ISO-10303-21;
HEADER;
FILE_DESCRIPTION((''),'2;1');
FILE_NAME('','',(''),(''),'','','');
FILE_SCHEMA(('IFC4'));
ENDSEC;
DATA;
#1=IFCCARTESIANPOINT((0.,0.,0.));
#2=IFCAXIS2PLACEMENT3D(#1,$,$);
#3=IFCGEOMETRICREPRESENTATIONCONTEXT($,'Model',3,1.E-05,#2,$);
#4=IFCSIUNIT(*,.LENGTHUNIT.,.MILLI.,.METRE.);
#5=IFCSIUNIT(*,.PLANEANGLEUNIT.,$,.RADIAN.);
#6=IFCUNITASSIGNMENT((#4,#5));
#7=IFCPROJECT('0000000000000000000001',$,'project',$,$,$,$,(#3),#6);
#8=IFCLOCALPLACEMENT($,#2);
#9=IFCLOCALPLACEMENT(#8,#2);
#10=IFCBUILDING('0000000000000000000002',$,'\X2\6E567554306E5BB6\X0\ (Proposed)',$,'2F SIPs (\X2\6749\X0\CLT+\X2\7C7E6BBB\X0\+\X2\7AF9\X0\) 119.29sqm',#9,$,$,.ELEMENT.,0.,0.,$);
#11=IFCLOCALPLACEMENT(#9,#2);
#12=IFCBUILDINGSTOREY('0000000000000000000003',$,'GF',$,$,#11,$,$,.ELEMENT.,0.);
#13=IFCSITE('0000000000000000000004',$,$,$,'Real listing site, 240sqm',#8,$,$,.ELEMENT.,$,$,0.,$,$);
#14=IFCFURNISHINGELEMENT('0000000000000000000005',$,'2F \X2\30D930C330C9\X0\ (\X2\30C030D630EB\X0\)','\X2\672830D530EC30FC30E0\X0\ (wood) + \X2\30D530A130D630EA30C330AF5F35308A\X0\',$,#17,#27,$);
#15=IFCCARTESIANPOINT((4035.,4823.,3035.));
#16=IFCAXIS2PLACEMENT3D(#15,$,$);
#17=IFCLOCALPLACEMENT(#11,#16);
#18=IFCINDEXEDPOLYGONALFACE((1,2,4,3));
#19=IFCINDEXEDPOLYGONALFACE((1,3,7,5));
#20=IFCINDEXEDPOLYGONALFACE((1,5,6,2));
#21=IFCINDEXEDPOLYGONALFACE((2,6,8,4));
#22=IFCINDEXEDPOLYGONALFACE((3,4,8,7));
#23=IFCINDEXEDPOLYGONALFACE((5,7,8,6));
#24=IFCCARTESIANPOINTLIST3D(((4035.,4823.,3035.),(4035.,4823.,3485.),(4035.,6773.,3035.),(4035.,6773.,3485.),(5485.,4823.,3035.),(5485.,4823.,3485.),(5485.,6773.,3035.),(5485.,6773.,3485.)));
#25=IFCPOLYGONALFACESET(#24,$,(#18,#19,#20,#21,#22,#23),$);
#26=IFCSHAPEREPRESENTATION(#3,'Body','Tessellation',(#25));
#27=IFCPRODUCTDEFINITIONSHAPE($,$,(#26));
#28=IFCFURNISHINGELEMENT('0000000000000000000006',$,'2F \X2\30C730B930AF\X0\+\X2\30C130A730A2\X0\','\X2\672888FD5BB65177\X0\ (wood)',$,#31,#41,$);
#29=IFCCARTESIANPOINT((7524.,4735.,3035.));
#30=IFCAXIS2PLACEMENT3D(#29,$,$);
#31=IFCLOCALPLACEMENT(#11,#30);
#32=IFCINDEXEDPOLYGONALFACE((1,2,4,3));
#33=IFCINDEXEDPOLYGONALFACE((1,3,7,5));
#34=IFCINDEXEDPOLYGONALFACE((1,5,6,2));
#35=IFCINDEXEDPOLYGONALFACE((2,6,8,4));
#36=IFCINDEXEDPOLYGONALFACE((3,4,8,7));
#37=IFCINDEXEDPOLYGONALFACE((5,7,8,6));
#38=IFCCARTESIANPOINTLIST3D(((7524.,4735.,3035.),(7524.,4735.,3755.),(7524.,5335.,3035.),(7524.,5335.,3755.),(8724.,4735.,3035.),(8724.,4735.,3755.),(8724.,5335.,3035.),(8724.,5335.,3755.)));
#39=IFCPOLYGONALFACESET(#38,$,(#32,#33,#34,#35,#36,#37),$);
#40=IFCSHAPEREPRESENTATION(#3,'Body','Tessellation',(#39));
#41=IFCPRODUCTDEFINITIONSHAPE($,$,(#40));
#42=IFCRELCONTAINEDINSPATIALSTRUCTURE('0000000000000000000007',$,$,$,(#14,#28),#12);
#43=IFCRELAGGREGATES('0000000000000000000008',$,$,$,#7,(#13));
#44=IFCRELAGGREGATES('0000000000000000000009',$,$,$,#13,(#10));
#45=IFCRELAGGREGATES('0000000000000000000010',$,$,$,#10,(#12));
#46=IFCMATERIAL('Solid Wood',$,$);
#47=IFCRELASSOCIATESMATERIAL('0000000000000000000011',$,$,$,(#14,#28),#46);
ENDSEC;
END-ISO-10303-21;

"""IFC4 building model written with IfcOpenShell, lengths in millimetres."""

from ifc_helpers import new_model, si_unit, frame, frame_2d, origin, place, context, project, spatial, rectangle, extrude, material, element, save


model = new_model("IFC4")

# Units and contexts
model_context = context("Model", 3, precision=1e-05, world=origin())
ifc_project = project(units=[si_unit("LENGTHUNIT", "METRE", prefix="MILLI"), si_unit("PLANEANGLEUNIT", "RADIAN")], contexts=[model_context])

# Site, building, storey
site_placement = place(None, origin())
site = spatial("IfcSite", under=ifc_project, at=site_placement, ObjectType="Real listing site, 240sqm", CompositionType="ELEMENT", RefElevation=0.0)
building_placement = place(site_placement, origin())
building = spatial("IfcBuilding", under=site, at=building_placement, Name="湖畔の家 (Proposed)", ObjectType="2F SIPs (杉CLT+籾殻+竹) 119.29sqm", CompositionType="ELEMENT", ElevationOfRefHeight=0.0, ElevationOfTerrain=0.0)
storey_placement = place(building_placement, origin())
storey = spatial("IfcBuildingStorey", under=building, at=storey_placement, Name="GF", CompositionType="ELEMENT", Elevation=0.0)

# Shared definitions
ifc_material_1 = material(Name="Solid Wood")

# Furnishing elements
furnishing_1_placement = place(storey_placement, frame((4035.0, 4823.0, 3035.0)))
element("IfcFurnishingElement", 1, at=furnishing_1_placement, inside=storey, material=ifc_material_1, Name="2F ベッド (ダブル)", Description="木フレーム (wood) + ファブリック張り", context=model_context, shape_type="SweptSolid", body=[
    extrude(rectangle(XDim=1450.0, YDim=1950.0, at=frame_2d((725.0, 975.0))), frame((4035.0, 4823.0, 3035.0)), (0.0, 0.0, 1.0), 450.0),
])
furnishing_2_placement = place(storey_placement, frame((7524.0, 4735.0, 3035.0)))
element("IfcFurnishingElement", 2, at=furnishing_2_placement, inside=storey, material=ifc_material_1, Name="2F デスク+チェア", Description="木製家具 (wood)", context=model_context, shape_type="SweptSolid", body=[
    extrude(rectangle(XDim=1200.0, YDim=600.0, at=frame_2d((600.0, 300.0))), frame((7524.0, 4735.0, 3035.0)), (0.0, 0.0, 1.0), 720.0),
])

save(model, "model.ifc")
